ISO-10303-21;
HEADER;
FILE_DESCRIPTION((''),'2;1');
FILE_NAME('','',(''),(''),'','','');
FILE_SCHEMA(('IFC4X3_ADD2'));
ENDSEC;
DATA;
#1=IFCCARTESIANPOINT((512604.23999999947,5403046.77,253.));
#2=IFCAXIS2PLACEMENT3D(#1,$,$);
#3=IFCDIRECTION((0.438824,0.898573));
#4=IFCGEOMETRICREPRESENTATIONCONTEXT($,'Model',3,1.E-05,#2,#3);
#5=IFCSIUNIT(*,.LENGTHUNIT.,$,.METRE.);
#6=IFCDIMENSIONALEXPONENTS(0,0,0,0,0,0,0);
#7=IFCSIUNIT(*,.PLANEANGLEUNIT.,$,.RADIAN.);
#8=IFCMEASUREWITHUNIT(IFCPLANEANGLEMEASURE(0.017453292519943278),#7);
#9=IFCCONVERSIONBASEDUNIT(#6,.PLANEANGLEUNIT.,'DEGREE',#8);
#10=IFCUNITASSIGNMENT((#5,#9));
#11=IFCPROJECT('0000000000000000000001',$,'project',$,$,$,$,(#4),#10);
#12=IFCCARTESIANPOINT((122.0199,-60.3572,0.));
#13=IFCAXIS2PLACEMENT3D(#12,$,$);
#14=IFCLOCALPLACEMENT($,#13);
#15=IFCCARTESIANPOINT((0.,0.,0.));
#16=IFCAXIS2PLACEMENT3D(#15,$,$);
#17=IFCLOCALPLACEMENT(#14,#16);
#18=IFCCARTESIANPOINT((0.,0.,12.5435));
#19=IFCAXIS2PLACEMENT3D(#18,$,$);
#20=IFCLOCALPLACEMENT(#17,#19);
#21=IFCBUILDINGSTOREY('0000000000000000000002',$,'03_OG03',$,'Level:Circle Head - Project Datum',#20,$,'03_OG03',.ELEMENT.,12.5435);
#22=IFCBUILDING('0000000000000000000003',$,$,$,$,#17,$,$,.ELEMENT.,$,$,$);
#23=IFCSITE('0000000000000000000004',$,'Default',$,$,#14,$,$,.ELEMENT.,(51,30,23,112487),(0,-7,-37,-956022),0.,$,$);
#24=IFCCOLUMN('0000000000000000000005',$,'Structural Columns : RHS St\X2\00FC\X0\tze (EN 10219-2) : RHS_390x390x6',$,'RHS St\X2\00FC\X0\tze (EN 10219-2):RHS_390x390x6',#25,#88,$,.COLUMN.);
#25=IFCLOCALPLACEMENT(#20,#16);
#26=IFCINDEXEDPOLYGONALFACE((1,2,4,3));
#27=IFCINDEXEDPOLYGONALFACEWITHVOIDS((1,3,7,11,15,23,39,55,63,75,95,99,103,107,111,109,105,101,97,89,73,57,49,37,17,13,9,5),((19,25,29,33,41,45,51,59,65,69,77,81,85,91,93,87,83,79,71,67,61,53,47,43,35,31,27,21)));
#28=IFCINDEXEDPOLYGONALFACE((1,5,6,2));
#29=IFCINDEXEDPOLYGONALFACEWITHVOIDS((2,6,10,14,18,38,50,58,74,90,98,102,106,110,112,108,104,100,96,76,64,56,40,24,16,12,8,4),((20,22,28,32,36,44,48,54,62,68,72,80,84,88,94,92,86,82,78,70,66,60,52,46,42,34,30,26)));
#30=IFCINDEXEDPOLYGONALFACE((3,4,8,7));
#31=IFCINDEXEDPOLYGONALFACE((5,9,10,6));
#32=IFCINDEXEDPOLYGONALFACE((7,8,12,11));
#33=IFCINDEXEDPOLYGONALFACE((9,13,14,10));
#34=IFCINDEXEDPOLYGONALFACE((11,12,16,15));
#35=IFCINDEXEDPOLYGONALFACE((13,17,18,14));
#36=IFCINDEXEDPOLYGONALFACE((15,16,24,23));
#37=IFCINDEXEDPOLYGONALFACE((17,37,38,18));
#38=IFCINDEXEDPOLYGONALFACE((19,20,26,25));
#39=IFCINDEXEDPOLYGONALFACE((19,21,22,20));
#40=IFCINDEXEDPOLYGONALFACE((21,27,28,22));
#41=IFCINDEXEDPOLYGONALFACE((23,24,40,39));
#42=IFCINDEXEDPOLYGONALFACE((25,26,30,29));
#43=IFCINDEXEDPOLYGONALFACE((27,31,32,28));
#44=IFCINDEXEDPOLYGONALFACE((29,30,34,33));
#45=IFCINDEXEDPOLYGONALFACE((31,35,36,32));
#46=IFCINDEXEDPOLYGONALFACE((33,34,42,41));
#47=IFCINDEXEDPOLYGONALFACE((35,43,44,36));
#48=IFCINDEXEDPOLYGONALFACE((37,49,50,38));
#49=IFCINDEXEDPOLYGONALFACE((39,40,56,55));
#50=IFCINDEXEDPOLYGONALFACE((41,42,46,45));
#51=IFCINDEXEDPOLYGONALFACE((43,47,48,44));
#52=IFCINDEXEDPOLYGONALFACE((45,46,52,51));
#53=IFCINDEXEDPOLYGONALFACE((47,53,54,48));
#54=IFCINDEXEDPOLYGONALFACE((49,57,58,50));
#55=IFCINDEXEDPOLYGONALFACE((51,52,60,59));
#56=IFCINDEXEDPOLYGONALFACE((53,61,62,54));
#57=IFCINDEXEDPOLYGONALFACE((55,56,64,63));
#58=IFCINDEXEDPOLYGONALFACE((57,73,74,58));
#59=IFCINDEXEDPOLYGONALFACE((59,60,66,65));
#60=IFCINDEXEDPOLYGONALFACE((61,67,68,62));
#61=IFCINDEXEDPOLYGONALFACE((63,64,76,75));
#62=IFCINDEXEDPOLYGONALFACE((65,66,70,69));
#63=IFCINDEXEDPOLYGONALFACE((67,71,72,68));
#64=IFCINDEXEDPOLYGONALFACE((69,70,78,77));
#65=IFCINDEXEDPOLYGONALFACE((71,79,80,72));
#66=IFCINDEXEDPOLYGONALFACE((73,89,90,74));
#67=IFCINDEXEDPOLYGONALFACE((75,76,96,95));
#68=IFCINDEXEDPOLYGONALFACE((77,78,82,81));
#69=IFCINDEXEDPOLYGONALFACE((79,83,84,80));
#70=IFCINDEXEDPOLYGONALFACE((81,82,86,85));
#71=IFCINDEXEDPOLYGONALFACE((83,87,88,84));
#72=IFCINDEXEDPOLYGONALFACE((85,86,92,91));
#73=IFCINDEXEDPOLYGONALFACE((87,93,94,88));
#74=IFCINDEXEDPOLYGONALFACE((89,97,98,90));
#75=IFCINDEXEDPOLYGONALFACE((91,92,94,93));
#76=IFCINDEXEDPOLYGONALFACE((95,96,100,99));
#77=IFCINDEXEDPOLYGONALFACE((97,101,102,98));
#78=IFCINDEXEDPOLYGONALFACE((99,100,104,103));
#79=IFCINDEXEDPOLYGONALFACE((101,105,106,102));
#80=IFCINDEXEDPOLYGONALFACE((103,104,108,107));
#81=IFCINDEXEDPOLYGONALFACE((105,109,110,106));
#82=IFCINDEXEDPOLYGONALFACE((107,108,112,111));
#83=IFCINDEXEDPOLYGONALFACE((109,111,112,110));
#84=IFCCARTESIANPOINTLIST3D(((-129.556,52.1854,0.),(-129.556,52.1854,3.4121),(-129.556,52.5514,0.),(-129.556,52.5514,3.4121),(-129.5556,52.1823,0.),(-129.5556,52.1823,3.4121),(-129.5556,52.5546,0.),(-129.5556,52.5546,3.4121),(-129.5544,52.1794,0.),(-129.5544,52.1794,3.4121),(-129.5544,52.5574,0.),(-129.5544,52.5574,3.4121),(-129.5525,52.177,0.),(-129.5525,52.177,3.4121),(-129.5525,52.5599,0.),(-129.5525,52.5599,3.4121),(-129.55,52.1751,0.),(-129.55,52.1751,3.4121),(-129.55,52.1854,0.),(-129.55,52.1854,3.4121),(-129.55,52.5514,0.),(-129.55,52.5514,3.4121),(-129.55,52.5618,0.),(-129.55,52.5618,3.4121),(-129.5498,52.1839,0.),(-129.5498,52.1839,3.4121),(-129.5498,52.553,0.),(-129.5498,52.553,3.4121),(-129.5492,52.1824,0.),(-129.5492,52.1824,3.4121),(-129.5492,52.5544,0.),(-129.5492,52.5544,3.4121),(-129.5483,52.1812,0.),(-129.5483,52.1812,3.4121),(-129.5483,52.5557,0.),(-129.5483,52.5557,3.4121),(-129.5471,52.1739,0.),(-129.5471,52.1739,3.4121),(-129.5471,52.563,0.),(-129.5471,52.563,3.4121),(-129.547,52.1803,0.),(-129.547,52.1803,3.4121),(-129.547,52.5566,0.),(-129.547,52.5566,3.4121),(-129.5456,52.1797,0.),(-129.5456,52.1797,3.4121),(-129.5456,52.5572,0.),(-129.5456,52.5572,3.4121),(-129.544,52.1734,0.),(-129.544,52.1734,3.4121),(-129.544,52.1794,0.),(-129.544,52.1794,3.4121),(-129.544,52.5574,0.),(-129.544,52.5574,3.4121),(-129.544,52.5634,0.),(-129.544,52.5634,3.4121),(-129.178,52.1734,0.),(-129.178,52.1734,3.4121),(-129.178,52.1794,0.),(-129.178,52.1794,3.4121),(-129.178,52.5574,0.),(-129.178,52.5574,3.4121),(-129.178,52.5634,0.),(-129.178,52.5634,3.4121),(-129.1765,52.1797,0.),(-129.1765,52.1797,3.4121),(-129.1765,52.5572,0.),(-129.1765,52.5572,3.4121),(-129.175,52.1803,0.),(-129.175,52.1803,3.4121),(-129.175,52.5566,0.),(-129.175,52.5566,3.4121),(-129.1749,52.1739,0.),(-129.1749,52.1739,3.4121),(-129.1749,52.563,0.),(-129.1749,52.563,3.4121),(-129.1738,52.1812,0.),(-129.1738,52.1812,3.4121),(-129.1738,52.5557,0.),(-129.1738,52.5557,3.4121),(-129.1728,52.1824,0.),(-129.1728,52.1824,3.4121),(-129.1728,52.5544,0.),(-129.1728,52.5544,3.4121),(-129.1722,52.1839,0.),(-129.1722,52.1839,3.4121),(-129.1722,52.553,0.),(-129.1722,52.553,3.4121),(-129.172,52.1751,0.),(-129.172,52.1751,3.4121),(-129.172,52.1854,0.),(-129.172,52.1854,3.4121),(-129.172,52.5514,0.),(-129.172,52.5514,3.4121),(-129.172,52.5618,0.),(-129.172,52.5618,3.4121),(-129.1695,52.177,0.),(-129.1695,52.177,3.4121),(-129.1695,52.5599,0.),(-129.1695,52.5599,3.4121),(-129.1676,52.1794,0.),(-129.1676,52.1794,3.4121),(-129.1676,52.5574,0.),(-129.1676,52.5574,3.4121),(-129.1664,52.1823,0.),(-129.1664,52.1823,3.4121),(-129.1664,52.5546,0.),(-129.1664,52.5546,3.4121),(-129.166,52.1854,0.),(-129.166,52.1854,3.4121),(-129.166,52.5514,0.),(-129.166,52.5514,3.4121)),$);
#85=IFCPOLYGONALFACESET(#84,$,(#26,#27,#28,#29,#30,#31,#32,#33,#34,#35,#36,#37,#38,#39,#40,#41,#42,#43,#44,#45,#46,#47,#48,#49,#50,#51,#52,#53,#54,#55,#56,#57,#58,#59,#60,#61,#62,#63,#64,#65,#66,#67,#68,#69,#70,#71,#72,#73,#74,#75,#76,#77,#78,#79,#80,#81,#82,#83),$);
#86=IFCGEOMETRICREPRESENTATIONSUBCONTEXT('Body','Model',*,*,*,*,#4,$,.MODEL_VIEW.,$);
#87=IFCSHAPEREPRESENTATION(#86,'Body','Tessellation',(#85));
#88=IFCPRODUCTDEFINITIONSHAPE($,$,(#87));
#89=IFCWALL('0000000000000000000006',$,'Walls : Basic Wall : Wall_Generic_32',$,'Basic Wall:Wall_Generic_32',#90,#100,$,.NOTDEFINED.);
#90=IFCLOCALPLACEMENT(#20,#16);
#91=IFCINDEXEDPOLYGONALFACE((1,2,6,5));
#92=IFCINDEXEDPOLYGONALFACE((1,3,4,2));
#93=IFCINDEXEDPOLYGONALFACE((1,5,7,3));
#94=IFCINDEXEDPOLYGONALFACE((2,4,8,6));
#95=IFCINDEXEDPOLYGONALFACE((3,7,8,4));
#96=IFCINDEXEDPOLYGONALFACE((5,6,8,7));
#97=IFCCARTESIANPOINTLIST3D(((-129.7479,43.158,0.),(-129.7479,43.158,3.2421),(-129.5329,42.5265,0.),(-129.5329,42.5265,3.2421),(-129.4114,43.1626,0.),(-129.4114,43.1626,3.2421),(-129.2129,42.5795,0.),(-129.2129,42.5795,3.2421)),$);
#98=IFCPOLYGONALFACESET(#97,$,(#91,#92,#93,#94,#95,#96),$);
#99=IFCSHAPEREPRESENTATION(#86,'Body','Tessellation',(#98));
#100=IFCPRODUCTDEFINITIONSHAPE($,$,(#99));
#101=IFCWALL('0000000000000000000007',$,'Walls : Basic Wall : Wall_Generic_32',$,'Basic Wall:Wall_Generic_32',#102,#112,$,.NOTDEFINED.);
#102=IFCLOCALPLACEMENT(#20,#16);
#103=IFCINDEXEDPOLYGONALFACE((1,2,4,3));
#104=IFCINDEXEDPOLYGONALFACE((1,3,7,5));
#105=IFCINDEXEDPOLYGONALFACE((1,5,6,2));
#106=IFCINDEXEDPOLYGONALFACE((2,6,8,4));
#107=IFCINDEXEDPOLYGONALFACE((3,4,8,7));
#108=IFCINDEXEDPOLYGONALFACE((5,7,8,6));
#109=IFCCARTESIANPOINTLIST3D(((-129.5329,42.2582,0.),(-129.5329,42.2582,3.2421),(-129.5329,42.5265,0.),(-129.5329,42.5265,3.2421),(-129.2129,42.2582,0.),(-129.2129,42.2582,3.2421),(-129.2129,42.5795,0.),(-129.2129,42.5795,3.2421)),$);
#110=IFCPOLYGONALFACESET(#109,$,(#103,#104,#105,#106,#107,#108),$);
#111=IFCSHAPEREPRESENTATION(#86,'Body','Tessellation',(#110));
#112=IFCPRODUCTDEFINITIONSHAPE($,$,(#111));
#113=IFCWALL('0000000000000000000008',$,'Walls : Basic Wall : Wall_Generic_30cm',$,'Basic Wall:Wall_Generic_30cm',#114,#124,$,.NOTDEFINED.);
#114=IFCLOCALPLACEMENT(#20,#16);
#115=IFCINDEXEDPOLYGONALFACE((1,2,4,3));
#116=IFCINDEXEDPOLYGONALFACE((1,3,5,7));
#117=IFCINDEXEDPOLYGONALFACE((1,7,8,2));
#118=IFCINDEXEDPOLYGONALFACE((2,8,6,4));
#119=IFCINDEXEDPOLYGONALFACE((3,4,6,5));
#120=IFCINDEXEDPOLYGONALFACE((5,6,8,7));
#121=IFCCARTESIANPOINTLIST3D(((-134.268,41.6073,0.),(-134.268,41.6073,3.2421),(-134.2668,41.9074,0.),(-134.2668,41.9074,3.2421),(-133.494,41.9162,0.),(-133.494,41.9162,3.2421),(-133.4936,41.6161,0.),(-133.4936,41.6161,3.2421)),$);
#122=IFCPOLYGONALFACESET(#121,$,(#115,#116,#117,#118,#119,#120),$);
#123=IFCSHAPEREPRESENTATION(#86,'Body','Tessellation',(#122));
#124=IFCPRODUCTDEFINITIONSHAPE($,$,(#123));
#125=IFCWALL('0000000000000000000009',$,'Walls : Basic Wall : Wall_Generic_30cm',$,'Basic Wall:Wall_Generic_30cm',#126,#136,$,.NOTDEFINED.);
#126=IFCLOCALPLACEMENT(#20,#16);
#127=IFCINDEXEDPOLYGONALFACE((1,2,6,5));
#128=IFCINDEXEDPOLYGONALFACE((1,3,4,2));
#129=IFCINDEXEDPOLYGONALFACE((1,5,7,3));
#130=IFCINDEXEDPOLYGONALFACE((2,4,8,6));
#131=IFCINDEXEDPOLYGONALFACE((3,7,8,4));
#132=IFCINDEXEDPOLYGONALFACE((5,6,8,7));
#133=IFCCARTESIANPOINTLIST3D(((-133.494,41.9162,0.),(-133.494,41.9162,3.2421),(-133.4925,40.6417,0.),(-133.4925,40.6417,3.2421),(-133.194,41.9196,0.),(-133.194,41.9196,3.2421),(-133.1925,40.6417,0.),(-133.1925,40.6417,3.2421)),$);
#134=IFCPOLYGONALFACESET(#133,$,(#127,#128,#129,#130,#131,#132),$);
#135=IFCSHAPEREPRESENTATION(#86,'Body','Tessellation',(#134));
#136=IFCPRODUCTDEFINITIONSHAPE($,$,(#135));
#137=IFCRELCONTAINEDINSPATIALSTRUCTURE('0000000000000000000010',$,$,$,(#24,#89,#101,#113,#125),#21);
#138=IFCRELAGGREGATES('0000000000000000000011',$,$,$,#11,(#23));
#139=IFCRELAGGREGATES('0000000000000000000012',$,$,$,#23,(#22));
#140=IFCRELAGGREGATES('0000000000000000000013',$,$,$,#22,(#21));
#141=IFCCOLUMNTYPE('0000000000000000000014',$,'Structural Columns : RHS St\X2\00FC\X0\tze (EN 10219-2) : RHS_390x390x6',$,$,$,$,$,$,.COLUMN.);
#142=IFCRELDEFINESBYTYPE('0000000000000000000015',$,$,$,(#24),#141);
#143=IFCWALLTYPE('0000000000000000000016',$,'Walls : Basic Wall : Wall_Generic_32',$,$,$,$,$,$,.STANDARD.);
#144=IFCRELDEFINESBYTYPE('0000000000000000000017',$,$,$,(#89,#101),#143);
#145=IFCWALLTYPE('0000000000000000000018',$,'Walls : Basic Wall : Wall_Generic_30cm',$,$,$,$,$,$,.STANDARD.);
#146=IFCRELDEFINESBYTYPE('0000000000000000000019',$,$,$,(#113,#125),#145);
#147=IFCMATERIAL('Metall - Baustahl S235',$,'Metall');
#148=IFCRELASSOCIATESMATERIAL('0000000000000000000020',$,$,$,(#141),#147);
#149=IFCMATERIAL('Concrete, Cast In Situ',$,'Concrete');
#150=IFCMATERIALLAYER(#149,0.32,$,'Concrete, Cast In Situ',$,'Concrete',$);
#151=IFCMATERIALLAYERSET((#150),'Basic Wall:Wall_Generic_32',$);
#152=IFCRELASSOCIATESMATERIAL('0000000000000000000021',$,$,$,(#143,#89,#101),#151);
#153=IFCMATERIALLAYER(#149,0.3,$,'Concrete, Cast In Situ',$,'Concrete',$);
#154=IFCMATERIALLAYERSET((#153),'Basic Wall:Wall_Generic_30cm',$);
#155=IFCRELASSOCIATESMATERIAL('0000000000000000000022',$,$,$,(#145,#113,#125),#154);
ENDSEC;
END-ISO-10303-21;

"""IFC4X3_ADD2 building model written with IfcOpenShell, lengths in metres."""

from ifc_helpers import new_model, entity, si_unit, converted_unit, direction, frame, frame_2d, origin, place, context, subcontext, project, spatial, polyline, circle_curve, parameter, trimmed, segment, composite_curve, outline, extrude, clip, bounded_halfspace, source, transform, mapped, material, layer, layer_set, material_profile, profile_set, type_object, type_shapes, element, save


model = new_model("IFC4X3_ADD2")

# Units and contexts
model_context = context("Model", 3, precision=1e-05, world=frame((512604.23999999947, 5403046.77, 253.0)), true_north=direction((0.438824, 0.898573)))
body_context = subcontext(model_context, "Body", "Model", "MODEL_VIEW")
ifc_project = project(units=[si_unit("LENGTHUNIT", "METRE"), converted_unit("PLANEANGLEUNIT", "DEGREE", entity("IfcPlaneAngleMeasure", 0.017453292519943278), si_unit("PLANEANGLEUNIT", "RADIAN"), dimensions=[0, 0, 0, 0, 0, 0, 0])], contexts=[model_context])

# Site, building, storey
site_placement = place(None, frame((122.0199, -60.3572, 0.0)))
site = spatial("IfcSite", under=ifc_project, at=site_placement, Name="Default", CompositionType="ELEMENT", RefLatitude=(51, 30, 23, 112487), RefLongitude=(0, -7, -37, -956022), RefElevation=0.0)
building_placement = place(site_placement, origin())
building = spatial("IfcBuilding", under=site, at=building_placement, CompositionType="ELEMENT")
storey_placement = place(building_placement, frame((0.0, 0.0, 12.5435)))
storey = spatial("IfcBuildingStorey", under=building, at=storey_placement, Name="03_OG03", ObjectType="Level:Circle Head - Project Datum", LongName="03_OG03", CompositionType="ELEMENT", Elevation=12.5435)

# Column
ifc_material_1 = material(Name="Metall - Baustahl S235", Category="Metall")
ifc_material_profile = material_profile(ifc_material_1, outline(composite_curve([segment(polyline([(-0.183, -0.195), (0.183, -0.195)]), True, "CONTINUOUS"), segment(trimmed(circle_curve(frame_2d((0.183, -0.183), x_axis=(-1.0, 0.0)), 0.012), [parameter(90.0)], [parameter(180.0)], True, "PARAMETER"), True, "CONTINUOUS"), segment(polyline([(0.195, -0.183), (0.195, 0.183)]), True, "CONTINUOUS"), segment(trimmed(circle_curve(frame_2d((0.183, 0.183), x_axis=(-1.0, 0.0)), 0.012), [parameter(180.0)], [parameter(270.0)], True, "PARAMETER"), True, "CONTINUOUS"), segment(polyline([(0.183, 0.195), (-0.183, 0.195)]), True, "CONTINUOUS"), segment(trimmed(circle_curve(frame_2d((-0.183, 0.183), x_axis=(-1.0, 0.0)), 0.012), [parameter(270.0)], [parameter(360.0)], True, "PARAMETER"), True, "CONTINUOUS"), segment(polyline([(-0.195, 0.183), (-0.195, -0.183)]), True, "CONTINUOUS"), segment(trimmed(circle_curve(frame_2d((-0.183, -0.183), x_axis=(-1.0, 0.0)), 0.012), [parameter(360.0)], [parameter(90.0)], True, "PARAMETER"), True, "CONTINUOUS")], self_intersect=False), holes=[composite_curve([segment(trimmed(circle_curve(frame_2d((-0.183, -0.183), x_axis=(-1.0, 0.0)), 0.006), [parameter(0.0)], [parameter(90.0)], True, "PARAMETER"), False, "CONTINUOUS"), segment(polyline([(-0.189, -0.183), (-0.189, 0.183)]), True, "CONTINUOUS"), segment(trimmed(circle_curve(frame_2d((-0.183, 0.183), x_axis=(-1.0, 0.0)), 0.006), [parameter(270.0)], [parameter(0.0)], True, "PARAMETER"), False, "CONTINUOUS"), segment(polyline([(-0.183, 0.189), (0.183, 0.189)]), True, "CONTINUOUS"), segment(trimmed(circle_curve(frame_2d((0.183, 0.183), x_axis=(-1.0, 0.0)), 0.006), [parameter(180.0)], [parameter(270.0)], True, "PARAMETER"), False, "CONTINUOUS"), segment(polyline([(0.189, 0.183), (0.189, -0.183)]), True, "CONTINUOUS"), segment(trimmed(circle_curve(frame_2d((0.183, -0.183), x_axis=(-1.0, 0.0)), 0.006), [parameter(90.0)], [parameter(180.0)], True, "PARAMETER"), False, "CONTINUOUS"), segment(polyline([(0.183, -0.189), (-0.183, -0.189)]), True, "CONTINUOUS")], self_intersect=False)]), Name="RHS_390x390x6")
ifc_profile_set = profile_set([ifc_material_profile], Name="RHS_390x390x6")
column_type_1 = type_object("IfcColumnType", Name="Structural Columns : RHS Stütze (EN 10219-2) : RHS_390x390x6", PredefinedType="COLUMN", material=ifc_profile_set)
shared_shape_1 = source(origin(), body_context, "Body", "SweptSolid", [
    extrude(outline(composite_curve([segment(polyline([(-0.183, -0.195), (0.183, -0.195)]), True, "CONTINUOUS"), segment(trimmed(circle_curve(frame_2d((0.183, -0.183), x_axis=(-1.0, 0.0)), 0.012), [parameter(90.0)], [parameter(180.0)], True, "PARAMETER"), True, "CONTINUOUS"), segment(polyline([(0.195, -0.183), (0.195, 0.183)]), True, "CONTINUOUS"), segment(trimmed(circle_curve(frame_2d((0.183, 0.183), x_axis=(-1.0, 0.0)), 0.012), [parameter(180.0)], [parameter(270.0)], True, "PARAMETER"), True, "CONTINUOUS"), segment(polyline([(0.183, 0.195), (-0.183, 0.195)]), True, "CONTINUOUS"), segment(trimmed(circle_curve(frame_2d((-0.183, 0.183), x_axis=(-1.0, 0.0)), 0.012), [parameter(270.0)], [parameter(360.0)], True, "PARAMETER"), True, "CONTINUOUS"), segment(polyline([(-0.195, 0.183), (-0.195, -0.183)]), True, "CONTINUOUS"), segment(trimmed(circle_curve(frame_2d((-0.183, -0.183), x_axis=(-1.0, 0.0)), 0.012), [parameter(360.0)], [parameter(90.0)], True, "PARAMETER"), True, "CONTINUOUS")], self_intersect=False), holes=[composite_curve([segment(trimmed(circle_curve(frame_2d((-0.183, -0.183), x_axis=(-1.0, 0.0)), 0.006), [parameter(0.0)], [parameter(90.0)], True, "PARAMETER"), False, "CONTINUOUS"), segment(polyline([(-0.189, -0.183), (-0.189, 0.183)]), True, "CONTINUOUS"), segment(trimmed(circle_curve(frame_2d((-0.183, 0.183), x_axis=(-1.0, 0.0)), 0.006), [parameter(270.0)], [parameter(0.0)], True, "PARAMETER"), False, "CONTINUOUS"), segment(polyline([(-0.183, 0.189), (0.183, 0.189)]), True, "CONTINUOUS"), segment(trimmed(circle_curve(frame_2d((0.183, 0.183), x_axis=(-1.0, 0.0)), 0.006), [parameter(180.0)], [parameter(270.0)], True, "PARAMETER"), False, "CONTINUOUS"), segment(polyline([(0.189, 0.183), (0.189, -0.183)]), True, "CONTINUOUS"), segment(trimmed(circle_curve(frame_2d((0.183, -0.183), x_axis=(-1.0, 0.0)), 0.006), [parameter(90.0)], [parameter(180.0)], True, "PARAMETER"), False, "CONTINUOUS"), segment(polyline([(0.183, -0.189), (-0.183, -0.189)]), True, "CONTINUOUS")], self_intersect=False)]), frame((0.0, 0.0, 12.5435), z_axis=(0.0, 0.0, 1.0), x_axis=(-1.0, 0.0, 0.0)), (0.0, 0.0, 1.0), 3.4121),
])
type_shapes(column_type_1, [shared_shape_1])
column_1_placement = place(storey_placement, frame((-129.361, 52.3684, -12.5435)))
element("IfcColumn", 1, at=column_1_placement, inside=storey, type_object=column_type_1, Name="Structural Columns : RHS Stütze (EN 10219-2) : RHS_390x390x6", ObjectType="RHS Stütze (EN 10219-2):RHS_390x390x6", PredefinedType="COLUMN", context=body_context, shape_type="MappedRepresentation", body=[
    mapped(shared_shape_1, transform((0.0, 0.0, 0.0), scale=1.0)),
])

# Walls
ifc_material_2 = material(Name="Concrete, Cast In Situ", Category="Concrete")
ifc_layer_1 = layer(ifc_material_2, 0.32, Name="Concrete, Cast In Situ", Category="Concrete")
ifc_layer_set_1 = layer_set([ifc_layer_1], Name="Basic Wall:Wall_Generic_32")
wall_type_1 = type_object("IfcWallType", Name="Walls : Basic Wall : Wall_Generic_32", PredefinedType="STANDARD", material=ifc_layer_set_1)
wall_1_placement = place(storey_placement, frame((-129.5965, 43.2096, 0.0), z_axis=(0.0, 0.0, 1.0), x_axis=(0.322277, -0.946645, 0.0)))
element("IfcWall", 2, at=wall_1_placement, inside=storey, type_object=wall_type_1, material=ifc_layer_set_1, Name="Walls : Basic Wall : Wall_Generic_32", ObjectType="Basic Wall:Wall_Generic_32", PredefinedType="NOTDEFINED", context=body_context, shape_type="Clipping", body=[
    clip(extrude(outline(polyline([(0.6671, -0.16), (0.7201, 0.16), (0.1041, 0.16), (0.0, -0.16), (0.3365, -0.16), (0.6671, -0.16)])), origin(), (0.0, 0.0, 1.0), 3.2421), bounded_halfspace(frame((0.0, -0.16, 3.2421), z_axis=(0.0, 0.0, -1.0), x_axis=(0.945727, -0.324962, 0.0)), True, frame((0.0, -0.16, 3.2421)), polyline([(0.0, 0.0), (0.3365, 0.0), (0.6671, 0.0), (0.7201, 0.32), (0.1041, 0.32), (0.0, 0.0)]))),
])
wall_2_placement = place(storey_placement, frame((-129.3729, 42.5795, 0.0), z_axis=(0.0, 0.0, 1.0), x_axis=(0.0, -1.0, 0.0)))
element("IfcWall", 3, at=wall_2_placement, inside=storey, type_object=wall_type_1, material=ifc_layer_set_1, Name="Walls : Basic Wall : Wall_Generic_32", ObjectType="Basic Wall:Wall_Generic_32", PredefinedType="NOTDEFINED", context=body_context, shape_type="Clipping", body=[
    clip(extrude(outline(polyline([(0.3213, -0.16), (0.3213, 0.16), (0.2013, 0.16), (0.0, 0.16), (0.053, -0.16), (0.3213, -0.16)])), origin(), (0.0, 0.0, 1.0), 3.2421), bounded_halfspace(frame((0.053, -0.16, 3.2421), z_axis=(0.0, 0.0, -1.0), x_axis=(0.999996, -0.002837, 0.0)), True, frame((0.053, -0.16, 3.2421)), polyline([(0.0, 0.0), (0.2683, 0.0), (0.2683, 0.32), (-0.053, 0.32), (0.0, 0.0)]))),
])
ifc_layer_2 = layer(ifc_material_2, 0.3, Name="Concrete, Cast In Situ", Category="Concrete")
ifc_layer_set_2 = layer_set([ifc_layer_2], Name="Basic Wall:Wall_Generic_30cm")
wall_type_2 = type_object("IfcWallType", Name="Walls : Basic Wall : Wall_Generic_30cm", PredefinedType="STANDARD", material=ifc_layer_set_2)
wall_3_placement = place(storey_placement, frame((-134.2697, 41.7573, 0.0), z_axis=(0.0, 0.0, 1.0), x_axis=(0.999935, 0.011366, 0.0)))
element("IfcWall", 4, at=wall_3_placement, inside=storey, type_object=wall_type_2, material=ifc_layer_set_2, Name="Walls : Basic Wall : Wall_Generic_30cm", ObjectType="Basic Wall:Wall_Generic_30cm", PredefinedType="NOTDEFINED", context=body_context, shape_type="Clipping", body=[
    clip(extrude(outline(polyline([(0.7744, -0.15), (0.7775, 0.15), (0.0047, 0.15), (0.0, -0.15), (0.7744, -0.15)])), origin(), (0.0, 0.0, 1.0), 3.2421), bounded_halfspace(frame((0.0, -0.15, 3.2421), z_axis=(0.0, 0.0, -1.0), x_axis=(-0.014203, -0.999899, 0.0)), True, frame((0.0, -0.15, 3.2421)), polyline([(0.0, 0.0), (0.7744, 0.0), (0.7775, 0.3), (0.0047, 0.3), (0.0, 0.0)]))),
])
wall_4_placement = place(storey_placement, frame((-133.344, 41.9194, 0.0), z_axis=(0.0, 0.0, 1.0), x_axis=(0.001183, -0.999999, 0.0)))
element("IfcWall", 5, at=wall_4_placement, inside=storey, type_object=wall_type_2, material=ifc_layer_set_2, Name="Walls : Basic Wall : Wall_Generic_30cm", ObjectType="Basic Wall:Wall_Generic_30cm", PredefinedType="NOTDEFINED", context=body_context, shape_type="Clipping", body=[
    clip(extrude(outline(polyline([(1.2775, -0.15), (1.2778, 0.15), (0.665, 0.15), (0.365, 0.15), (0.0, 0.15), (0.0031, -0.15), (0.3031, -0.15), (1.2775, -0.15)])), origin(), (0.0, 0.0, 1.0), 3.2421), bounded_halfspace(frame((0.0031, -0.15, 3.2421), z_axis=(0.0, 0.0, -1.0), x_axis=(0.999992, -0.004021, 0.0)), True, frame((0.0031, -0.15, 3.2421)), polyline([(0.0, 0.0), (0.3, 0.0), (1.2744, 0.0), (1.2748, 0.3), (0.6619, 0.3), (0.3619, 0.3), (-0.0031, 0.3), (0.0, 0.0)]))),
])

save(model, "model.ifc")
